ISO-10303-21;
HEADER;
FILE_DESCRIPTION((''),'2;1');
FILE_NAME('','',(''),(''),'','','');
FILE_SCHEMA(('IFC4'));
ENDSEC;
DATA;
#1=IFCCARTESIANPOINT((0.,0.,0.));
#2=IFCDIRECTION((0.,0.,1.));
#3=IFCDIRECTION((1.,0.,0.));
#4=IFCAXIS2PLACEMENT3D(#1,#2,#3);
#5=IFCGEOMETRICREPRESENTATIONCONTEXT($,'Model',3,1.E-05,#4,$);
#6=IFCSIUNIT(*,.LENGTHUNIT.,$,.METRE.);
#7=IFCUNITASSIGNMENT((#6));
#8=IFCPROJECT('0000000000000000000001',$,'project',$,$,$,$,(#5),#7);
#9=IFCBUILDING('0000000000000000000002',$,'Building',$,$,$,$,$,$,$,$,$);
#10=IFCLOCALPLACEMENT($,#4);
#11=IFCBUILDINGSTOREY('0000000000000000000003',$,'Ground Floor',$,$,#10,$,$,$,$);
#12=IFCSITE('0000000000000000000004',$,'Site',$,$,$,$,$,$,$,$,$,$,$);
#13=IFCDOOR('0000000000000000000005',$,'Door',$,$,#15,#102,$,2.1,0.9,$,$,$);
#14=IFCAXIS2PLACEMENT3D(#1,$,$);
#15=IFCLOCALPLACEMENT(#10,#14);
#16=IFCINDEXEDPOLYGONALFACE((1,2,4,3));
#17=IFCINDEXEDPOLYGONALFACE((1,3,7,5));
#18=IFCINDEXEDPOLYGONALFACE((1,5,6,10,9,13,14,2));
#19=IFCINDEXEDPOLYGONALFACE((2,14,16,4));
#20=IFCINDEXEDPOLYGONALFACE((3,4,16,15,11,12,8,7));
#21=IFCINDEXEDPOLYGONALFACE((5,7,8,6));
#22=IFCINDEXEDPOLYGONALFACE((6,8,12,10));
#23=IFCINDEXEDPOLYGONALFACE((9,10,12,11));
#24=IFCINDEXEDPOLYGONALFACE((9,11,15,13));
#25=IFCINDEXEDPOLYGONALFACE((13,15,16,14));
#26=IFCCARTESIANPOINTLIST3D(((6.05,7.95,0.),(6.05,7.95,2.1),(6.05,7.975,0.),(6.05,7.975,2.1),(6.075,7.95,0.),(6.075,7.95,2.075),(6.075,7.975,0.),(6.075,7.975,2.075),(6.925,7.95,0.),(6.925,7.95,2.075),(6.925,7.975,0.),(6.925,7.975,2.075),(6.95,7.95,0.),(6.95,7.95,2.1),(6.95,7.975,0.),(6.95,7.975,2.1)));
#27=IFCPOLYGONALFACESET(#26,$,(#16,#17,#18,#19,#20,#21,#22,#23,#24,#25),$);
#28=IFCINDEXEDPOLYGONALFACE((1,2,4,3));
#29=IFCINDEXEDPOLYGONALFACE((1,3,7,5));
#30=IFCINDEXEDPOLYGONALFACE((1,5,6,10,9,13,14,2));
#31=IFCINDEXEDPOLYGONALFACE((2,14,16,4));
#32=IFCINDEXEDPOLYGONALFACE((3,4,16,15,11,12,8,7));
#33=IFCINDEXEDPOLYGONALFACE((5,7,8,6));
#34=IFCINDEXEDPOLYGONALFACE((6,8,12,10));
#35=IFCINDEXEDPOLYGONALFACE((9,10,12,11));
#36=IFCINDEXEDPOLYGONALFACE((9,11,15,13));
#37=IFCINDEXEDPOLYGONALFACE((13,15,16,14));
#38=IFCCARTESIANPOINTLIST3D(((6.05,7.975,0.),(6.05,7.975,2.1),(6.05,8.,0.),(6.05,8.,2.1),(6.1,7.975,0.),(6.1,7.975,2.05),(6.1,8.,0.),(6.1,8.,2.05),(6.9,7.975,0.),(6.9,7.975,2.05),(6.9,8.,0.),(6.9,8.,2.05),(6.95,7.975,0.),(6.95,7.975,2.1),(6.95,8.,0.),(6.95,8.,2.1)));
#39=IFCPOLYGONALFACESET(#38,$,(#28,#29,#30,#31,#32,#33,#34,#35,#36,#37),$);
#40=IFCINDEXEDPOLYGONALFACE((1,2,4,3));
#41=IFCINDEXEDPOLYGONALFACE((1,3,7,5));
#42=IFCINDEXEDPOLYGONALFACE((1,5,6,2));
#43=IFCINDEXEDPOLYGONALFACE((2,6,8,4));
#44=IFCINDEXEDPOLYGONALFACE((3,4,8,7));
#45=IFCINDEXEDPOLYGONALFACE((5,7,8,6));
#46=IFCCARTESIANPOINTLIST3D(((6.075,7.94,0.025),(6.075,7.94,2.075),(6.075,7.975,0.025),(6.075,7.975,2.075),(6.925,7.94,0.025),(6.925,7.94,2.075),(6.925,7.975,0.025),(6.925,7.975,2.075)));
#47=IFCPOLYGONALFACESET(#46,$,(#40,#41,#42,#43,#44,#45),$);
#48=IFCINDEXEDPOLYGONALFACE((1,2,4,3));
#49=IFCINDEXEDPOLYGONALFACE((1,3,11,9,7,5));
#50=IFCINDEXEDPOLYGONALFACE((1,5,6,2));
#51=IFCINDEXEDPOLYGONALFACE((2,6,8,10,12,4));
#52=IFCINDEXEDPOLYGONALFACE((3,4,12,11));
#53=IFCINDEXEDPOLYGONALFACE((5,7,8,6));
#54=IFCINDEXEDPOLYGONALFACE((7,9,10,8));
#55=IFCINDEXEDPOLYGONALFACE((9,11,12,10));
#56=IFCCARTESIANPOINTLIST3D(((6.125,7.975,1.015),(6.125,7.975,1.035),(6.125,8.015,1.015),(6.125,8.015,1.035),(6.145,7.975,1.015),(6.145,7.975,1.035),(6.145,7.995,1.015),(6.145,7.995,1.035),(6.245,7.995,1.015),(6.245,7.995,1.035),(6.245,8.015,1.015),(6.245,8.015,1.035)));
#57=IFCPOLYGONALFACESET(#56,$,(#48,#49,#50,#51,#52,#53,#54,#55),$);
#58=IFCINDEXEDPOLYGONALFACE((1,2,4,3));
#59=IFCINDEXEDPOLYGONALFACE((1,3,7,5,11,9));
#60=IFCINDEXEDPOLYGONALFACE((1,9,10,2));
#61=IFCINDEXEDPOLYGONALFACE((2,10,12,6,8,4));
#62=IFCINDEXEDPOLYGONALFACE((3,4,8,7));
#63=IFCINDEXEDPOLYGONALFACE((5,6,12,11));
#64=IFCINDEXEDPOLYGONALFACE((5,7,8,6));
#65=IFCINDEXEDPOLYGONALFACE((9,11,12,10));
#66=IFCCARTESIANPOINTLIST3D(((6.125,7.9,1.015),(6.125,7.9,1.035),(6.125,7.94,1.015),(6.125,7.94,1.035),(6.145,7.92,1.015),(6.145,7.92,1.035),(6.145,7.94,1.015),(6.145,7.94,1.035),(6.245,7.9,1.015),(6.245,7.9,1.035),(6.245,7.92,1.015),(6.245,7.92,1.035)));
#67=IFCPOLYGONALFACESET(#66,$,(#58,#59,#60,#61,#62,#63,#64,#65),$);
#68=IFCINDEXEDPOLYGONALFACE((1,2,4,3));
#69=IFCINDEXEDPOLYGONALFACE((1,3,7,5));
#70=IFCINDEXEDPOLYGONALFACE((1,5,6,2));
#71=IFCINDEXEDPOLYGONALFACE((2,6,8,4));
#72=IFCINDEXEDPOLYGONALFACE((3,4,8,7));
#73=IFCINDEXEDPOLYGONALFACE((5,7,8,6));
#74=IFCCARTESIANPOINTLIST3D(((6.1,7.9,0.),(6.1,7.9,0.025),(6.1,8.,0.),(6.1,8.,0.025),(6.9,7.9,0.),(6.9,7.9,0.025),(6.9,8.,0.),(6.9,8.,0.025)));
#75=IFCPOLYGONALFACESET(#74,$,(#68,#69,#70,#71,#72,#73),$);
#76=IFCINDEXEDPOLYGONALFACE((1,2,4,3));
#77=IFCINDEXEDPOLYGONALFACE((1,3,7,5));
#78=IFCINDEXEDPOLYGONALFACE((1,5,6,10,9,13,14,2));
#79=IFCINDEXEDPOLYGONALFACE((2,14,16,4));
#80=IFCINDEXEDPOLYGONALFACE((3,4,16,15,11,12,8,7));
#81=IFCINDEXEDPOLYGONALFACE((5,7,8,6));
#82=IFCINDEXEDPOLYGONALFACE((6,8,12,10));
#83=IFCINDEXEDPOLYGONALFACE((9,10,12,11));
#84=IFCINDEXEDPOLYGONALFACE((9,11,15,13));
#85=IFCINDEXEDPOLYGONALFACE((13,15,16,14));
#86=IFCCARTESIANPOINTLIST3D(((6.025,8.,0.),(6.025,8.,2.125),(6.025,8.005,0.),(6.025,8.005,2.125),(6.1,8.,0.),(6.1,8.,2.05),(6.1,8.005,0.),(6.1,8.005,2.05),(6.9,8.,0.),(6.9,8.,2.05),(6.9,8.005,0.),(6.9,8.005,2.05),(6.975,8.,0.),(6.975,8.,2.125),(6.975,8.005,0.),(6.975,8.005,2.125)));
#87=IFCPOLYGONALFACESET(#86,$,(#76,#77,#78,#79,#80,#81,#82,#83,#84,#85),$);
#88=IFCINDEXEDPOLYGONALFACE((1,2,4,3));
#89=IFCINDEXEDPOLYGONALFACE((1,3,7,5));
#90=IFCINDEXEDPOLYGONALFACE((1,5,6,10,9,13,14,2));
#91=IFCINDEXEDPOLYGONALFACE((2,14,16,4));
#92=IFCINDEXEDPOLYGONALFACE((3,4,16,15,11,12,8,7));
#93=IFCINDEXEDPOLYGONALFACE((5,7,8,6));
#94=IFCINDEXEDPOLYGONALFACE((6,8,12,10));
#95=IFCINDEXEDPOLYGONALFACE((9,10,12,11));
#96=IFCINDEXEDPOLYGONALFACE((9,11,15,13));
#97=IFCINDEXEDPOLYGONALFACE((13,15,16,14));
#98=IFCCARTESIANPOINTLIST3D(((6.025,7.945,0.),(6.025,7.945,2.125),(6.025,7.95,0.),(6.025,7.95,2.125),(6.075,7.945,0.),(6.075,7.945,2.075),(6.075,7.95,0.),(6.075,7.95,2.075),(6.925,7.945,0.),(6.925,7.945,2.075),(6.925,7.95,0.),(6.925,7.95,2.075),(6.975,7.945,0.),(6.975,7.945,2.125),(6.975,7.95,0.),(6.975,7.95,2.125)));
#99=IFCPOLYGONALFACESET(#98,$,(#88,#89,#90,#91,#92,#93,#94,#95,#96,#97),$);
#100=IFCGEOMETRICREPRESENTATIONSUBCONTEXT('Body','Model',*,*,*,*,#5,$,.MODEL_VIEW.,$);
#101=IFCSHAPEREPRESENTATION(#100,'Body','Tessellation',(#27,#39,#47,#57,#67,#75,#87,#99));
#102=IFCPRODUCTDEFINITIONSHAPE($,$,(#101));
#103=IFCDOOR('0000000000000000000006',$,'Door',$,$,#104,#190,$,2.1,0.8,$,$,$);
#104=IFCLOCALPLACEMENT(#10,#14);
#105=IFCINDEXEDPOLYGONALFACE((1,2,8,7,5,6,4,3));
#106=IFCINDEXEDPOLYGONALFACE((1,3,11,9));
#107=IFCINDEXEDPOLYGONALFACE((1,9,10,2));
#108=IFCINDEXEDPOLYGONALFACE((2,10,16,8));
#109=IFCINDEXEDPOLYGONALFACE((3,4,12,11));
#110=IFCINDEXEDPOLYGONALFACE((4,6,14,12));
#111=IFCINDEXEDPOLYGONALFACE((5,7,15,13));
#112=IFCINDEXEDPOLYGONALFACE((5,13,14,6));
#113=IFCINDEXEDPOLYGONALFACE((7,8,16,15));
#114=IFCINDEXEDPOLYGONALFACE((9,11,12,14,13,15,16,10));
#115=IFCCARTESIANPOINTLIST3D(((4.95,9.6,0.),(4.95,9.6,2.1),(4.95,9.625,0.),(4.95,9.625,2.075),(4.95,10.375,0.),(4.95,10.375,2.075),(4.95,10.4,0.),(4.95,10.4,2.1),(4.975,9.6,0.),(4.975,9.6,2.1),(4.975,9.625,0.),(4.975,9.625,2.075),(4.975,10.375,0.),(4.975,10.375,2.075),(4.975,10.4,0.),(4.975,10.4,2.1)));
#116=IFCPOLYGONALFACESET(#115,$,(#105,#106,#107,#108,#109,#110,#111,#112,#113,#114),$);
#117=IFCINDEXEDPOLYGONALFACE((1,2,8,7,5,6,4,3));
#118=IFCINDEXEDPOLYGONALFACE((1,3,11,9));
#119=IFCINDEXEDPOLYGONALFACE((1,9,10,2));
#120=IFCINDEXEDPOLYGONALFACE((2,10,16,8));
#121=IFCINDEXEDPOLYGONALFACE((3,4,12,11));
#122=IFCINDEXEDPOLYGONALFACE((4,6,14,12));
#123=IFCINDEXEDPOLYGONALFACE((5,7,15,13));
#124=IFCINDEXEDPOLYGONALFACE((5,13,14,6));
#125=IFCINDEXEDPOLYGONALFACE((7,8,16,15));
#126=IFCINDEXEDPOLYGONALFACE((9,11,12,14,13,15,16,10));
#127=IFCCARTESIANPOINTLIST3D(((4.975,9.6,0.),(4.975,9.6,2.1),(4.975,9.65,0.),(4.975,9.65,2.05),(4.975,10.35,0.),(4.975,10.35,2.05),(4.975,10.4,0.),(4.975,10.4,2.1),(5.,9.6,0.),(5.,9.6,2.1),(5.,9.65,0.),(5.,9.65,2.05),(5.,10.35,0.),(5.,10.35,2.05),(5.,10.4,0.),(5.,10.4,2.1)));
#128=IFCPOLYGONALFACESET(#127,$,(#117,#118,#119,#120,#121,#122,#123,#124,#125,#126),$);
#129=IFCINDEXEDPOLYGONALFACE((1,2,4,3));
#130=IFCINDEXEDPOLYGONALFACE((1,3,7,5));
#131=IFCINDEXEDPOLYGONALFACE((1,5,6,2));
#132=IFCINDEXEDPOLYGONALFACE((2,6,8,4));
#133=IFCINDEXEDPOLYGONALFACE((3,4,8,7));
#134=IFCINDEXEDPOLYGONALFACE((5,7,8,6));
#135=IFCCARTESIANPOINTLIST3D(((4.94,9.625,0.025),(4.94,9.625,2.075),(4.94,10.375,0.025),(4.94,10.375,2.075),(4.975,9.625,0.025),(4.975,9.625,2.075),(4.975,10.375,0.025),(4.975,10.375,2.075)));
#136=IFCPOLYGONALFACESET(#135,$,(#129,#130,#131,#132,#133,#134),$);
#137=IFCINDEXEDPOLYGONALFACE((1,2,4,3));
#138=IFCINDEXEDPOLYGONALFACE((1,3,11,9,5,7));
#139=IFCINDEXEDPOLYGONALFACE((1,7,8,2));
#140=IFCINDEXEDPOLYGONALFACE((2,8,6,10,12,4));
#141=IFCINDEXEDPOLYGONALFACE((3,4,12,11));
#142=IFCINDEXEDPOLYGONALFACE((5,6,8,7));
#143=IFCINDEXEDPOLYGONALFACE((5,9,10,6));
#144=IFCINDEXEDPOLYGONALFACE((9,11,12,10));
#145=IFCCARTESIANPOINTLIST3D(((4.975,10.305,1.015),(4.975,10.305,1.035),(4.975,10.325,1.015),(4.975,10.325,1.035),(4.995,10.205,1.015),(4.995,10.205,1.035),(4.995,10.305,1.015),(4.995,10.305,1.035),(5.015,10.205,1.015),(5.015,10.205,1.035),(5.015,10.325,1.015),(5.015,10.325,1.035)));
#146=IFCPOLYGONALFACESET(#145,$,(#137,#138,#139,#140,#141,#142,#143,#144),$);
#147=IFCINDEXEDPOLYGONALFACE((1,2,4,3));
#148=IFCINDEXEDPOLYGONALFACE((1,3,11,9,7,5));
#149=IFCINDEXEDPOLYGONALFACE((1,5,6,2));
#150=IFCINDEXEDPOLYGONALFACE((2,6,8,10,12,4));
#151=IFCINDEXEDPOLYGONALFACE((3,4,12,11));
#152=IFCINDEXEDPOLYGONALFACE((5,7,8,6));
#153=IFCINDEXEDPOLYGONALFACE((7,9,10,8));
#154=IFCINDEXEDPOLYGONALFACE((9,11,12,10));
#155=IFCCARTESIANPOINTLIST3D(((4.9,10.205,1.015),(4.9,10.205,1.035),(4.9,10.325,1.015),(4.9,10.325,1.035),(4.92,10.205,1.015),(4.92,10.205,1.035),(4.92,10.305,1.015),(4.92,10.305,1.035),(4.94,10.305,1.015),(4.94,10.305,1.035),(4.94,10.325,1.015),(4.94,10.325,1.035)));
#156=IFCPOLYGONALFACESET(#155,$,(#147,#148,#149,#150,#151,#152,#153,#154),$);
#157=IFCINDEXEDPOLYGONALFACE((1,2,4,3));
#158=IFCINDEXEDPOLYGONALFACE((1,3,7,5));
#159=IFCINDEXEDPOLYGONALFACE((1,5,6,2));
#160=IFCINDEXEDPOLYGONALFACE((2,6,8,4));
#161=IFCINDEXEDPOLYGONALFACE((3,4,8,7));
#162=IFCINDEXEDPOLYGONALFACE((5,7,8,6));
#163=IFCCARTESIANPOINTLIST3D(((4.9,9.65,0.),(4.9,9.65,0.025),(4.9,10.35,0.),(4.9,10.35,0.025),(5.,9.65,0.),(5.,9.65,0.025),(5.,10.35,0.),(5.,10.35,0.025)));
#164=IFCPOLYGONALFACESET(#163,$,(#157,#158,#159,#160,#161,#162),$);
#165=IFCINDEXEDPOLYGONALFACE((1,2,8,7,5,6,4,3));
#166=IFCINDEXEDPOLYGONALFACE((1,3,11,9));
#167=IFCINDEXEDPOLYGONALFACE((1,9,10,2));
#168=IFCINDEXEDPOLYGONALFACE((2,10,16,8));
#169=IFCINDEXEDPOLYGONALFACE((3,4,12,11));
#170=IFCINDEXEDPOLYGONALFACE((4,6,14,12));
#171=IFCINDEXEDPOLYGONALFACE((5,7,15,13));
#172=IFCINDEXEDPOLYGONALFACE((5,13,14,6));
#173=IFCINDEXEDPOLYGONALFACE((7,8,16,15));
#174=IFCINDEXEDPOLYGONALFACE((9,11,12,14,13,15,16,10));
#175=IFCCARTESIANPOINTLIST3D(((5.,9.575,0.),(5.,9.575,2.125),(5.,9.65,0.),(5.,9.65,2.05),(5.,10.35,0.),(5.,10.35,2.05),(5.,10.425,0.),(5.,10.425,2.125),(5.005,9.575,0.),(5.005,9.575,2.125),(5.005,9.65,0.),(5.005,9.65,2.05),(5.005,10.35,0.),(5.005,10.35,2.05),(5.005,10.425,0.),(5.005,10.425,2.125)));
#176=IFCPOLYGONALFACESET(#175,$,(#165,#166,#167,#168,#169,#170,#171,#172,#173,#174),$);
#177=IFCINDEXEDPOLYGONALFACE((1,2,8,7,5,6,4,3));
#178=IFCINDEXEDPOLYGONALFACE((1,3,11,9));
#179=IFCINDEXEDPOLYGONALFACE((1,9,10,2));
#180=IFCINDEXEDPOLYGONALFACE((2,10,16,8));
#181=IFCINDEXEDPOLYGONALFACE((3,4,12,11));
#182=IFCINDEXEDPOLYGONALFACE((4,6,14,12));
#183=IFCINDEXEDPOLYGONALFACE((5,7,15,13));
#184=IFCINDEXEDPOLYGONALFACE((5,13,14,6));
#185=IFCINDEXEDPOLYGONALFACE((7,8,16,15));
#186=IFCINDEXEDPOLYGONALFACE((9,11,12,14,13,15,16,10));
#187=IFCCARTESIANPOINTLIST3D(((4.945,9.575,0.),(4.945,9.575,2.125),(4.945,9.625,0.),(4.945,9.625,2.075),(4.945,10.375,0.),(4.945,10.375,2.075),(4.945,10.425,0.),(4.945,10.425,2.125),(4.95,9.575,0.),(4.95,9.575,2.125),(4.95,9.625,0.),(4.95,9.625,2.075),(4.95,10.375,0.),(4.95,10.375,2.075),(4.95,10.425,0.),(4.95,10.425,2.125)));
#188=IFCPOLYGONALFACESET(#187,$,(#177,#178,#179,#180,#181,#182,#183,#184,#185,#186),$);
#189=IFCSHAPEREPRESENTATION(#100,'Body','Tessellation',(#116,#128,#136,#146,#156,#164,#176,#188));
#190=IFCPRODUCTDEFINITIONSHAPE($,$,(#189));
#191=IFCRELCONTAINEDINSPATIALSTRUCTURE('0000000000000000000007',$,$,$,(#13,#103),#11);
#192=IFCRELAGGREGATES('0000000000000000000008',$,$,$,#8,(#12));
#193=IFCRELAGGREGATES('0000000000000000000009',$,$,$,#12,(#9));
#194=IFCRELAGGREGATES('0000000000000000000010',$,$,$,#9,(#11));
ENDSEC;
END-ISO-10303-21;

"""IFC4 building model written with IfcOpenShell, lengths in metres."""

from ifc_helpers import new_model, si_unit, frame, origin_with_axes, place, context, subcontext, project, spatial, line, indexed_curve, outline, extrude, element, save


model = new_model("IFC4")

# Units and contexts
model_context = context("Model", 3, precision=1e-05, world=origin_with_axes())
body_context = subcontext(model_context, "Body", "Model", "MODEL_VIEW")
ifc_project = project(units=[si_unit("LENGTHUNIT", "METRE")], contexts=[model_context])

# Site, building, storey
site = spatial("IfcSite", under=ifc_project, Name="Site")
building = spatial("IfcBuilding", under=site, Name="Building")
storey_placement = place(None, origin_with_axes())
storey = spatial("IfcBuildingStorey", under=building, at=storey_placement, Name="Ground Floor")

# Doors
door_1_placement = place(storey_placement, frame((6.95, 8.0, 0.0), z_axis=(0.0, 0.0, 1.0), x_axis=(-1.0, 0.0, 0.0)))
element("IfcDoor", 1, at=door_1_placement, inside=storey, Name="Door", OverallHeight=2.1, OverallWidth=0.9, context=body_context, shape_type="SweptSolid", body=[
    extrude(outline(indexed_curve([(0.0, 0.0), (0.0, 2.1), (0.9, 2.1), (0.9, 0.0), (0.875, 0.0), (0.875, 2.075), (0.025, 2.075), (0.025, 0.0)], segments=[line(1, 2, 3, 4, 5, 6, 7, 8, 1)])), frame((0.0, 0.025, 0.0), z_axis=(0.0, -1.0, 0.0), x_axis=(1.0, 0.0, 0.0)), (0.0, 0.0, -1.0), 0.025),
    extrude(outline(indexed_curve([(0.0, 0.0), (0.0, 2.1), (0.9, 2.1), (0.9, 0.0), (0.85, 0.0), (0.85, 2.05), (0.05, 2.05), (0.05, 0.0)], segments=[line(1, 2, 3, 4, 5, 6, 7, 8, 1)])), frame((0.0, 0.0, 0.0), z_axis=(0.0, -1.0, 0.0), x_axis=(1.0, 0.0, 0.0)), (0.0, 0.0, -1.0), 0.025),
    extrude(outline(indexed_curve([(0.0, 0.0), (0.85, 0.0), (0.85, 0.035), (0.0, 0.035)], segments=[line(1, 2, 3, 4, 1)])), frame((0.025, 0.025, 0.025), z_axis=(0.0, 0.0, 1.0), x_axis=(1.0, 0.0, 0.0)), (0.0, 0.0, 1.0), 2.05),
    extrude(outline(indexed_curve([(0.0, 0.0), (0.0, -0.04), (-0.12, -0.04), (-0.12, -0.02), (-0.02, -0.02), (-0.02, 0.0)], segments=[line(1, 2, 3, 4, 5, 6, 1)])), frame((0.825, 0.025, 1.015), z_axis=(0.0, 0.0, 1.0), x_axis=(1.0, 0.0, 0.0)), (0.0, 0.0, 1.0), 0.02),
    extrude(outline(indexed_curve([(0.0, 0.0), (0.0, 0.04), (-0.12, 0.04), (-0.12, 0.02), (-0.02, 0.02), (-0.02, 0.0)], segments=[line(1, 2, 3, 4, 5, 6, 1)])), frame((0.825, 0.06, 1.015), z_axis=(0.0, 0.0, 1.0), x_axis=(1.0, 0.0, 0.0)), (0.0, 0.0, 1.0), 0.02),
    extrude(outline(indexed_curve([(0.0, 0.0), (0.8, 0.0), (0.8, 0.1), (0.0, 0.1)], segments=[line(1, 2, 3, 4, 1)])), frame((0.05, 0.0, 0.0), z_axis=(0.0, 0.0, 1.0), x_axis=(1.0, 0.0, 0.0)), (0.0, 0.0, 1.0), 0.025),
    extrude(outline(indexed_curve([(0.0, 0.0), (0.0, 2.125), (0.95, 2.125), (0.95, 0.0), (0.875, 0.0), (0.875, 2.05), (0.075, 2.05), (0.075, 0.0)], segments=[line(1, 2, 3, 4, 5, 6, 7, 8, 1)])), frame((-0.025, -0.005, 0.0), z_axis=(0.0, -1.0, 0.0), x_axis=(1.0, 0.0, 0.0)), (0.0, 0.0, -1.0), 0.005),
    extrude(outline(indexed_curve([(0.0, 0.0), (0.0, 2.125), (0.95, 2.125), (0.95, 0.0), (0.9, 0.0), (0.9, 2.075), (0.05, 2.075), (0.05, 0.0)], segments=[line(1, 2, 3, 4, 5, 6, 7, 8, 1)])), frame((-0.025, 0.05, 0.0), z_axis=(0.0, -1.0, 0.0), x_axis=(1.0, 0.0, 0.0)), (0.0, 0.0, -1.0), 0.005),
])
door_2_placement = place(storey_placement, frame((5.0, 9.6, 0.0), z_axis=(0.0, 0.0, 1.0), x_axis=(0.0, 1.0, 0.0)))
element("IfcDoor", 2, at=door_2_placement, inside=storey, Name="Door", OverallHeight=2.1, OverallWidth=0.8, context=body_context, shape_type="SweptSolid", body=[
    extrude(outline(indexed_curve([(0.0, 0.0), (0.0, 2.1), (0.8, 2.1), (0.8, 0.0), (0.775, 0.0), (0.775, 2.075), (0.025, 2.075), (0.025, 0.0)], segments=[line(1, 2, 3, 4, 5, 6, 7, 8, 1)])), frame((0.0, 0.025, 0.0), z_axis=(0.0, -1.0, 0.0), x_axis=(1.0, 0.0, 0.0)), (0.0, 0.0, -1.0), 0.025),
    extrude(outline(indexed_curve([(0.0, 0.0), (0.0, 2.1), (0.8, 2.1), (0.8, 0.0), (0.75, 0.0), (0.75, 2.05), (0.05, 2.05), (0.05, 0.0)], segments=[line(1, 2, 3, 4, 5, 6, 7, 8, 1)])), frame((0.0, 0.0, 0.0), z_axis=(0.0, -1.0, 0.0), x_axis=(1.0, 0.0, 0.0)), (0.0, 0.0, -1.0), 0.025),
    extrude(outline(indexed_curve([(0.0, 0.0), (0.75, 0.0), (0.75, 0.035), (0.0, 0.035)], segments=[line(1, 2, 3, 4, 1)])), frame((0.025, 0.025, 0.025), z_axis=(0.0, 0.0, 1.0), x_axis=(1.0, 0.0, 0.0)), (0.0, 0.0, 1.0), 2.05),
    extrude(outline(indexed_curve([(0.0, 0.0), (0.0, -0.04), (-0.12, -0.04), (-0.12, -0.02), (-0.02, -0.02), (-0.02, 0.0)], segments=[line(1, 2, 3, 4, 5, 6, 1)])), frame((0.725, 0.025, 1.015), z_axis=(0.0, 0.0, 1.0), x_axis=(1.0, 0.0, 0.0)), (0.0, 0.0, 1.0), 0.02),
    extrude(outline(indexed_curve([(0.0, 0.0), (0.0, 0.04), (-0.12, 0.04), (-0.12, 0.02), (-0.02, 0.02), (-0.02, 0.0)], segments=[line(1, 2, 3, 4, 5, 6, 1)])), frame((0.725, 0.06, 1.015), z_axis=(0.0, 0.0, 1.0), x_axis=(1.0, 0.0, 0.0)), (0.0, 0.0, 1.0), 0.02),
    extrude(outline(indexed_curve([(0.0, 0.0), (0.7, 0.0), (0.7, 0.1), (0.0, 0.1)], segments=[line(1, 2, 3, 4, 1)])), frame((0.05, 0.0, 0.0), z_axis=(0.0, 0.0, 1.0), x_axis=(1.0, 0.0, 0.0)), (0.0, 0.0, 1.0), 0.025),
    extrude(outline(indexed_curve([(0.0, 0.0), (0.0, 2.125), (0.85, 2.125), (0.85, 0.0), (0.775, 0.0), (0.775, 2.05), (0.075, 2.05), (0.075, 0.0)], segments=[line(1, 2, 3, 4, 5, 6, 7, 8, 1)])), frame((-0.025, -0.005, 0.0), z_axis=(0.0, -1.0, 0.0), x_axis=(1.0, 0.0, 0.0)), (0.0, 0.0, -1.0), 0.005),
    extrude(outline(indexed_curve([(0.0, 0.0), (0.0, 2.125), (0.85, 2.125), (0.85, 0.0), (0.8, 0.0), (0.8, 2.075), (0.05, 2.075), (0.05, 0.0)], segments=[line(1, 2, 3, 4, 5, 6, 7, 8, 1)])), frame((-0.025, 0.05, 0.0), z_axis=(0.0, -1.0, 0.0), x_axis=(1.0, 0.0, 0.0)), (0.0, 0.0, -1.0), 0.005),
])

save(model, "model.ifc")
